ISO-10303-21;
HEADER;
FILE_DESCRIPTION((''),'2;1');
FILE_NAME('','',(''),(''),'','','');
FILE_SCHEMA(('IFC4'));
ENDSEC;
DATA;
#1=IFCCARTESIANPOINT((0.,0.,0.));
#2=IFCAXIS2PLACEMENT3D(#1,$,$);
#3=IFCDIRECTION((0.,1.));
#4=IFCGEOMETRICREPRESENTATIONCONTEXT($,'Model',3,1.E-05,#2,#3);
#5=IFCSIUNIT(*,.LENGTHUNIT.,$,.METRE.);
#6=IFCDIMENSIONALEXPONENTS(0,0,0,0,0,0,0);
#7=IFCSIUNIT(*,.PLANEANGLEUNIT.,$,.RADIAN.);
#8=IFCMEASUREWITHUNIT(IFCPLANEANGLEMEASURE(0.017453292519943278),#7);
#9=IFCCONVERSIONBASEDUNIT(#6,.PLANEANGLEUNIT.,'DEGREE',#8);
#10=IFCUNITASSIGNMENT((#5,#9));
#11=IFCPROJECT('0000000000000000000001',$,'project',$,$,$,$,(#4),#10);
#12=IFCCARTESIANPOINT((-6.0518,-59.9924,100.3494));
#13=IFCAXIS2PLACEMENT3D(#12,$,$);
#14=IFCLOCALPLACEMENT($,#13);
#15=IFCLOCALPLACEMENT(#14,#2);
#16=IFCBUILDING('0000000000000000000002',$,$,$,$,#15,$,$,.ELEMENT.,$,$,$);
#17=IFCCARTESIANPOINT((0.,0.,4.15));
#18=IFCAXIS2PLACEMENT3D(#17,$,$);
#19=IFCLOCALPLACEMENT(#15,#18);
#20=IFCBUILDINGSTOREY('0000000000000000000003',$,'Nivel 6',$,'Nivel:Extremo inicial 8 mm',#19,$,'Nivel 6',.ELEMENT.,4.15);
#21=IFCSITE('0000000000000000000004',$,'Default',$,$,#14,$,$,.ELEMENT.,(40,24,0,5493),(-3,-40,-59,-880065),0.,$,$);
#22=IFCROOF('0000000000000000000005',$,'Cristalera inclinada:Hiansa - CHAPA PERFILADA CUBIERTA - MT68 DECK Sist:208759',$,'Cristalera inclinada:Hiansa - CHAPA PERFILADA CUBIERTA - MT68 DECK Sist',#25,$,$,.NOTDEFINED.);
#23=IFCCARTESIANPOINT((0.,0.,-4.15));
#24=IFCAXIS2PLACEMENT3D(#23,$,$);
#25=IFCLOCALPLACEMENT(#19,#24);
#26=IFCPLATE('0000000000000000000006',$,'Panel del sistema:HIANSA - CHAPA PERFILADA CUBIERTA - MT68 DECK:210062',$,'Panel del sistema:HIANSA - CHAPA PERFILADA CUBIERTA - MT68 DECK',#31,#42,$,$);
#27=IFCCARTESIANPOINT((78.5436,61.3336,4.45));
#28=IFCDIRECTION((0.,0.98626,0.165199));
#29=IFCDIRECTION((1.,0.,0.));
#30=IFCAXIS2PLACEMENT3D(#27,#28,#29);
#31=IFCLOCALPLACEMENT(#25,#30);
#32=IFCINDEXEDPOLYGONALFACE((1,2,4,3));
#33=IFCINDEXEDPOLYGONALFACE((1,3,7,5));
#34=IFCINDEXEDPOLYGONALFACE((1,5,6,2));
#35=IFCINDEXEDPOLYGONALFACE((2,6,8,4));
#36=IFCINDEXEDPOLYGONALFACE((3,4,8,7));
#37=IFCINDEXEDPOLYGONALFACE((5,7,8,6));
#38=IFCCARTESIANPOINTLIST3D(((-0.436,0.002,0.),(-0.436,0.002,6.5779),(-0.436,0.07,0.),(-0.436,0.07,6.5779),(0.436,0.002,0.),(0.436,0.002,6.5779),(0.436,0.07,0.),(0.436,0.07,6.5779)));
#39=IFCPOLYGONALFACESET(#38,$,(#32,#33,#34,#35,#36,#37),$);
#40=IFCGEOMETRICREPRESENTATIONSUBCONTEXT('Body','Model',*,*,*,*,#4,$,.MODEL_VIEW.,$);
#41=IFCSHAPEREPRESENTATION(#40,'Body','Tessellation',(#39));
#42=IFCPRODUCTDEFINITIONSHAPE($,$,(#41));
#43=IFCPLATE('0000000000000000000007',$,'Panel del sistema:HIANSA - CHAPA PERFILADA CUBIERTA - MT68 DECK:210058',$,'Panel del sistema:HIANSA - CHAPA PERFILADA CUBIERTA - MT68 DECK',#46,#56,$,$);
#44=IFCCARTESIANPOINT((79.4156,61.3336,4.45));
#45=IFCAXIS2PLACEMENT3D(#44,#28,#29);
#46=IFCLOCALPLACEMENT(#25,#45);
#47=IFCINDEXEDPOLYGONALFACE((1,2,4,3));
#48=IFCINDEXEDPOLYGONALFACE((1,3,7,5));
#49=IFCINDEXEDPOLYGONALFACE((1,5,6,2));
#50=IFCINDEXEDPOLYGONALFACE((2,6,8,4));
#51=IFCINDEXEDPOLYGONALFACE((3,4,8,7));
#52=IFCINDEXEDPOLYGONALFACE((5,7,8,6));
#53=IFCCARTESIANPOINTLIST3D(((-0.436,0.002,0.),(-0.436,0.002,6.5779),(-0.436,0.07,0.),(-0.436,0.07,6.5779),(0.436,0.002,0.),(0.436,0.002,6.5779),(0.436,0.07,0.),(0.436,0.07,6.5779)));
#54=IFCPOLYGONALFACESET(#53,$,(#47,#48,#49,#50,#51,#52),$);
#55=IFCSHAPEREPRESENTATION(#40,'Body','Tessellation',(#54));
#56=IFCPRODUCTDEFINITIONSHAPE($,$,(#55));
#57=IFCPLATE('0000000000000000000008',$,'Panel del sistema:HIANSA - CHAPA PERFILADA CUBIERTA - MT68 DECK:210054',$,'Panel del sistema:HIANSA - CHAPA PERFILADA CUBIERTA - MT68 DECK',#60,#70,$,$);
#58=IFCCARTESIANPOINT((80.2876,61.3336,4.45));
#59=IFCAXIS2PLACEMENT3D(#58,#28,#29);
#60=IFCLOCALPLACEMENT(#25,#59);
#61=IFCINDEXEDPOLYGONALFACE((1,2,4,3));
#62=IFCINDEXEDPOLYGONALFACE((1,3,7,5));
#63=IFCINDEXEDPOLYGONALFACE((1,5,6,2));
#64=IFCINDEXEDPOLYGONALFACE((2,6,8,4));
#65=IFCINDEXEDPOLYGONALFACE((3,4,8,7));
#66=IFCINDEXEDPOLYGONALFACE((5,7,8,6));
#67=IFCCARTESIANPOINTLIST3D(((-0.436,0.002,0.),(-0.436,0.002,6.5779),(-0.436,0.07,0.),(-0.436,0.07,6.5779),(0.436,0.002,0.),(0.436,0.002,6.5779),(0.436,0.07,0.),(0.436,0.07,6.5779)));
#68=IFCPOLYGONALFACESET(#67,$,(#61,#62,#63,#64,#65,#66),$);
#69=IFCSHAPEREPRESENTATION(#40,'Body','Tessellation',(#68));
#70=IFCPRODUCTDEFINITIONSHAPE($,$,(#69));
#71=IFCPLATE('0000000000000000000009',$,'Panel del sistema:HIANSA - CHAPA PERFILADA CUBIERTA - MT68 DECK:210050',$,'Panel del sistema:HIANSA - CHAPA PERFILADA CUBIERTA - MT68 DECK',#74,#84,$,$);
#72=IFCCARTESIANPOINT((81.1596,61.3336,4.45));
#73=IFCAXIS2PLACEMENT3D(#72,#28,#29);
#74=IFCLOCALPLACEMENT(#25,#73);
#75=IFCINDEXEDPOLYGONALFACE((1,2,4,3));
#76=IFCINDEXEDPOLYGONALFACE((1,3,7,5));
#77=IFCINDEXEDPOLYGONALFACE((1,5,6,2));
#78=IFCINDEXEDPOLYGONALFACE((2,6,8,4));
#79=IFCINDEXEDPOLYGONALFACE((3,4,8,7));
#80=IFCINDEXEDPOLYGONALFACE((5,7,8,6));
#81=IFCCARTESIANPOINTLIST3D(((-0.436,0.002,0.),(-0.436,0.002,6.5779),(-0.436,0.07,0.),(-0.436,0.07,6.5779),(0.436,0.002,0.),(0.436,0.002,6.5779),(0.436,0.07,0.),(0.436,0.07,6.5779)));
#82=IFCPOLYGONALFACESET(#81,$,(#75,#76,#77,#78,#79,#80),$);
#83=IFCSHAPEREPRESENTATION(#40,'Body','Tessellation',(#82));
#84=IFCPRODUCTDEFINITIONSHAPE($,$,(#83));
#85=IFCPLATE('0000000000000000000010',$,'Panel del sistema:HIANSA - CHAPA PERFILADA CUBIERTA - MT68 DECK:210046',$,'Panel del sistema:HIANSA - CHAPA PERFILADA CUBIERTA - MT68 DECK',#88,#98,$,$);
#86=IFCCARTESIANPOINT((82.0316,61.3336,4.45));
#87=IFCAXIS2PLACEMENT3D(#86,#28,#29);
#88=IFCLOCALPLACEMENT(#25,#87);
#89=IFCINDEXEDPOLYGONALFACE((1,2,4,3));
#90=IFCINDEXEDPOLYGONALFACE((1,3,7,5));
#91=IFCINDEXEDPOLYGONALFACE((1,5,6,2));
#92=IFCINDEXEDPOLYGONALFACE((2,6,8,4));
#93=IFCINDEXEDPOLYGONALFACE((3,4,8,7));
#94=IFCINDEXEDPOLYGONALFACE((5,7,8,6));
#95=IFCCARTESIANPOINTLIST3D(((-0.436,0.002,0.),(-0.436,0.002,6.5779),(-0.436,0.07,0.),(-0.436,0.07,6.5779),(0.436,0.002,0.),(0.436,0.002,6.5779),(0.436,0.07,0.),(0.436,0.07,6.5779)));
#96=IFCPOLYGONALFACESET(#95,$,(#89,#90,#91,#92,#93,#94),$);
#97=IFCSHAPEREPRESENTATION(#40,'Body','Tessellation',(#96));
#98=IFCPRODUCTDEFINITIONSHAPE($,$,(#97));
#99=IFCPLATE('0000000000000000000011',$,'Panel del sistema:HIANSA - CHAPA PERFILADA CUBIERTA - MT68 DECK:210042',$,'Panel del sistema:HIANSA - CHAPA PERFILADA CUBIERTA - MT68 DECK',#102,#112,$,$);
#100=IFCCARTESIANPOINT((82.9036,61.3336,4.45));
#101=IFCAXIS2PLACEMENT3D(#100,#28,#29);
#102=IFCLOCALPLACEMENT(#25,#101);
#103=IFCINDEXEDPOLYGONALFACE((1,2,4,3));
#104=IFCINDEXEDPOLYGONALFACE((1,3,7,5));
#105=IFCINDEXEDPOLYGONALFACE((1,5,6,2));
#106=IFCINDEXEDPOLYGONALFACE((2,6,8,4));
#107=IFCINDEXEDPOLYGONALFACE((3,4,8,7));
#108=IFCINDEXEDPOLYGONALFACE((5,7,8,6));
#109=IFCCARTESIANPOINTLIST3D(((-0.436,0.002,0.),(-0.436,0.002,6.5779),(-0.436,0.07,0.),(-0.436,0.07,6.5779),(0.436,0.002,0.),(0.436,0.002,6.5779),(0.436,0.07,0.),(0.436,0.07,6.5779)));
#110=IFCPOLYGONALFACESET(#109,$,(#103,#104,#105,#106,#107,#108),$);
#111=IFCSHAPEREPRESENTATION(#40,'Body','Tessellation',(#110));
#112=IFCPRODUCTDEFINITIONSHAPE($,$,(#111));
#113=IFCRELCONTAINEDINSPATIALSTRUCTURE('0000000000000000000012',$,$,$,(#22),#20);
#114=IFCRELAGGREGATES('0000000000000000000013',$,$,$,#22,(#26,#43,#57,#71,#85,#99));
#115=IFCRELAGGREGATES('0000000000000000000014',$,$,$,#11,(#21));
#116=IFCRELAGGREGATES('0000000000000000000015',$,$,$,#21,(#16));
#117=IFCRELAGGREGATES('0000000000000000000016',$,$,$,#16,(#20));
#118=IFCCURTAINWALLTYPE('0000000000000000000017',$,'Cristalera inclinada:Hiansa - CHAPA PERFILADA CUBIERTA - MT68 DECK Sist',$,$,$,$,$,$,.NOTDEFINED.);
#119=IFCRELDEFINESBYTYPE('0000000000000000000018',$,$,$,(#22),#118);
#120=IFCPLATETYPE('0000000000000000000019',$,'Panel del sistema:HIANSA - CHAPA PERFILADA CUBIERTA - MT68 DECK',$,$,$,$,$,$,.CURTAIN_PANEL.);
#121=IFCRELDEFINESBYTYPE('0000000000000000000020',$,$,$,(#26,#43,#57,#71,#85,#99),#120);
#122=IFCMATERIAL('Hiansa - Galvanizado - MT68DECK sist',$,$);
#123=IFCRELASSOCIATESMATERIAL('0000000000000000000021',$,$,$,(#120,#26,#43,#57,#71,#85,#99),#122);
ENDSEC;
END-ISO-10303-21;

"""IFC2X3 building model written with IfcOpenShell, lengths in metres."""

from ifc_helpers import new_model, entity, si_unit, converted_unit, direction, frame, origin, origin_2d_with_axis, place, context, subcontext, project, spatial, rectangle, extrude, source, transform, mapped, material, type_object, type_shapes, element, aggregate, save


model = new_model("IFC2X3")

# Units and contexts
model_context = context("Model", 3, precision=1e-05, world=origin(), true_north=direction((0.0, 1.0)))
body_context = subcontext(model_context, "Body", "Model", "MODEL_VIEW")
ifc_project = project(units=[si_unit("LENGTHUNIT", "METRE"), converted_unit("PLANEANGLEUNIT", "DEGREE", entity("IfcPlaneAngleMeasure", 0.017453292519943278), si_unit("PLANEANGLEUNIT", "RADIAN"), dimensions=[0, 0, 0, 0, 0, 0, 0])], contexts=[model_context])

# Site, building, storey
site_placement = place(None, frame((-6.0518, -59.9924, 100.3494)))
site = spatial("IfcSite", under=ifc_project, at=site_placement, Name="Default", CompositionType="ELEMENT", RefLatitude=(40, 24, 0, 5493), RefLongitude=(-3, -40, -59, -880065), RefElevation=0.0)
building_placement = place(site_placement, origin())
building = spatial("IfcBuilding", under=site, at=building_placement, CompositionType="ELEMENT")
storey_placement = place(building_placement, frame((0.0, 0.0, 4.15)))
storey = spatial("IfcBuildingStorey", under=building, at=storey_placement, Name="Nivel 6", ObjectType="Nivel:Extremo inicial 8 mm", LongName="Nivel 6", CompositionType="ELEMENT", Elevation=4.15)

# Roof, plates
curtain_wall_type = type_object("IfcCurtainWallType", Name="Cristalera inclinada:Hiansa - CHAPA PERFILADA CUBIERTA - MT68 DECK Sist", PredefinedType="NOTDEFINED")
roof_placement = place(storey_placement, frame((0.0, 0.0, -4.15)))
roof = element("IfcRoof", 1, at=roof_placement, inside=storey, type_object=curtain_wall_type, Name="Cristalera inclinada:Hiansa - CHAPA PERFILADA CUBIERTA - MT68 DECK Sist:208759", ObjectType="Cristalera inclinada:Hiansa - CHAPA PERFILADA CUBIERTA - MT68 DECK Sist", ShapeType="NOTDEFINED")
ifc_material_1 = material(Name="Hiansa - Galvanizado - MT68DECK sist")
plate_type_1 = type_object("IfcPlateType", Name="Panel del sistema:HIANSA - CHAPA PERFILADA CUBIERTA - MT68 DECK", PredefinedType="CURTAIN_PANEL", material=ifc_material_1)
shared_shape_1 = source(origin(), body_context, "Body", "SweptSolid", [
    extrude(rectangle(XDim=0.068, YDim=0.872, at=origin_2d_with_axis()), frame((0.0, 0.036, 0.0), z_axis=(0.0, 0.0, 1.0), x_axis=(0.0, 1.0, 0.0)), (0.0, 0.0, 1.0), 6.5779),
])
type_shapes(plate_type_1, [shared_shape_1])
plate_1_placement = place(roof_placement, frame((78.5436, 61.3336, 4.45), z_axis=(0.0, 0.98626, 0.165199), x_axis=(1.0, 0.0, 0.0)))
plate_1 = element("IfcPlate", 2, at=plate_1_placement, type_object=plate_type_1, material=ifc_material_1, Name="Panel del sistema:HIANSA - CHAPA PERFILADA CUBIERTA - MT68 DECK:210062", ObjectType="Panel del sistema:HIANSA - CHAPA PERFILADA CUBIERTA - MT68 DECK", context=body_context, shape_type="MappedRepresentation", body=[
    mapped(shared_shape_1, transform((0.0, 0.0, 0.0), scale=1.0)),
])
plate_2_placement = place(roof_placement, frame((79.4156, 61.3336, 4.45), z_axis=(0.0, 0.98626, 0.165199), x_axis=(1.0, 0.0, 0.0)))
plate_2 = element("IfcPlate", 3, at=plate_2_placement, type_object=plate_type_1, material=ifc_material_1, Name="Panel del sistema:HIANSA - CHAPA PERFILADA CUBIERTA - MT68 DECK:210058", ObjectType="Panel del sistema:HIANSA - CHAPA PERFILADA CUBIERTA - MT68 DECK", context=body_context, shape_type="MappedRepresentation", body=[
    mapped(shared_shape_1, transform((0.0, 0.0, 0.0), scale=1.0)),
])
plate_3_placement = place(roof_placement, frame((80.2876, 61.3336, 4.45), z_axis=(0.0, 0.98626, 0.165199), x_axis=(1.0, 0.0, 0.0)))
plate_3 = element("IfcPlate", 4, at=plate_3_placement, type_object=plate_type_1, material=ifc_material_1, Name="Panel del sistema:HIANSA - CHAPA PERFILADA CUBIERTA - MT68 DECK:210054", ObjectType="Panel del sistema:HIANSA - CHAPA PERFILADA CUBIERTA - MT68 DECK", context=body_context, shape_type="MappedRepresentation", body=[
    mapped(shared_shape_1, transform((0.0, 0.0, 0.0), scale=1.0)),
])
plate_4_placement = place(roof_placement, frame((81.1596, 61.3336, 4.45), z_axis=(0.0, 0.98626, 0.165199), x_axis=(1.0, 0.0, 0.0)))
plate_4 = element("IfcPlate", 5, at=plate_4_placement, type_object=plate_type_1, material=ifc_material_1, Name="Panel del sistema:HIANSA - CHAPA PERFILADA CUBIERTA - MT68 DECK:210050", ObjectType="Panel del sistema:HIANSA - CHAPA PERFILADA CUBIERTA - MT68 DECK", context=body_context, shape_type="MappedRepresentation", body=[
    mapped(shared_shape_1, transform((0.0, 0.0, 0.0), scale=1.0)),
])
plate_5_placement = place(roof_placement, frame((82.0316, 61.3336, 4.45), z_axis=(0.0, 0.98626, 0.165199), x_axis=(1.0, 0.0, 0.0)))
plate_5 = element("IfcPlate", 6, at=plate_5_placement, type_object=plate_type_1, material=ifc_material_1, Name="Panel del sistema:HIANSA - CHAPA PERFILADA CUBIERTA - MT68 DECK:210046", ObjectType="Panel del sistema:HIANSA - CHAPA PERFILADA CUBIERTA - MT68 DECK", context=body_context, shape_type="MappedRepresentation", body=[
    mapped(shared_shape_1, transform((0.0, 0.0, 0.0), scale=1.0)),
])
plate_6_placement = place(roof_placement, frame((82.9036, 61.3336, 4.45), z_axis=(0.0, 0.98626, 0.165199), x_axis=(1.0, 0.0, 0.0)))
plate_6 = element("IfcPlate", 7, at=plate_6_placement, type_object=plate_type_1, material=ifc_material_1, Name="Panel del sistema:HIANSA - CHAPA PERFILADA CUBIERTA - MT68 DECK:210042", ObjectType="Panel del sistema:HIANSA - CHAPA PERFILADA CUBIERTA - MT68 DECK", context=body_context, shape_type="MappedRepresentation", body=[
    mapped(shared_shape_1, transform((0.0, 0.0, 0.0), scale=1.0)),
])
aggregate(roof, [plate_1, plate_2, plate_3, plate_4, plate_5, plate_6])

save(model, "model.ifc")
